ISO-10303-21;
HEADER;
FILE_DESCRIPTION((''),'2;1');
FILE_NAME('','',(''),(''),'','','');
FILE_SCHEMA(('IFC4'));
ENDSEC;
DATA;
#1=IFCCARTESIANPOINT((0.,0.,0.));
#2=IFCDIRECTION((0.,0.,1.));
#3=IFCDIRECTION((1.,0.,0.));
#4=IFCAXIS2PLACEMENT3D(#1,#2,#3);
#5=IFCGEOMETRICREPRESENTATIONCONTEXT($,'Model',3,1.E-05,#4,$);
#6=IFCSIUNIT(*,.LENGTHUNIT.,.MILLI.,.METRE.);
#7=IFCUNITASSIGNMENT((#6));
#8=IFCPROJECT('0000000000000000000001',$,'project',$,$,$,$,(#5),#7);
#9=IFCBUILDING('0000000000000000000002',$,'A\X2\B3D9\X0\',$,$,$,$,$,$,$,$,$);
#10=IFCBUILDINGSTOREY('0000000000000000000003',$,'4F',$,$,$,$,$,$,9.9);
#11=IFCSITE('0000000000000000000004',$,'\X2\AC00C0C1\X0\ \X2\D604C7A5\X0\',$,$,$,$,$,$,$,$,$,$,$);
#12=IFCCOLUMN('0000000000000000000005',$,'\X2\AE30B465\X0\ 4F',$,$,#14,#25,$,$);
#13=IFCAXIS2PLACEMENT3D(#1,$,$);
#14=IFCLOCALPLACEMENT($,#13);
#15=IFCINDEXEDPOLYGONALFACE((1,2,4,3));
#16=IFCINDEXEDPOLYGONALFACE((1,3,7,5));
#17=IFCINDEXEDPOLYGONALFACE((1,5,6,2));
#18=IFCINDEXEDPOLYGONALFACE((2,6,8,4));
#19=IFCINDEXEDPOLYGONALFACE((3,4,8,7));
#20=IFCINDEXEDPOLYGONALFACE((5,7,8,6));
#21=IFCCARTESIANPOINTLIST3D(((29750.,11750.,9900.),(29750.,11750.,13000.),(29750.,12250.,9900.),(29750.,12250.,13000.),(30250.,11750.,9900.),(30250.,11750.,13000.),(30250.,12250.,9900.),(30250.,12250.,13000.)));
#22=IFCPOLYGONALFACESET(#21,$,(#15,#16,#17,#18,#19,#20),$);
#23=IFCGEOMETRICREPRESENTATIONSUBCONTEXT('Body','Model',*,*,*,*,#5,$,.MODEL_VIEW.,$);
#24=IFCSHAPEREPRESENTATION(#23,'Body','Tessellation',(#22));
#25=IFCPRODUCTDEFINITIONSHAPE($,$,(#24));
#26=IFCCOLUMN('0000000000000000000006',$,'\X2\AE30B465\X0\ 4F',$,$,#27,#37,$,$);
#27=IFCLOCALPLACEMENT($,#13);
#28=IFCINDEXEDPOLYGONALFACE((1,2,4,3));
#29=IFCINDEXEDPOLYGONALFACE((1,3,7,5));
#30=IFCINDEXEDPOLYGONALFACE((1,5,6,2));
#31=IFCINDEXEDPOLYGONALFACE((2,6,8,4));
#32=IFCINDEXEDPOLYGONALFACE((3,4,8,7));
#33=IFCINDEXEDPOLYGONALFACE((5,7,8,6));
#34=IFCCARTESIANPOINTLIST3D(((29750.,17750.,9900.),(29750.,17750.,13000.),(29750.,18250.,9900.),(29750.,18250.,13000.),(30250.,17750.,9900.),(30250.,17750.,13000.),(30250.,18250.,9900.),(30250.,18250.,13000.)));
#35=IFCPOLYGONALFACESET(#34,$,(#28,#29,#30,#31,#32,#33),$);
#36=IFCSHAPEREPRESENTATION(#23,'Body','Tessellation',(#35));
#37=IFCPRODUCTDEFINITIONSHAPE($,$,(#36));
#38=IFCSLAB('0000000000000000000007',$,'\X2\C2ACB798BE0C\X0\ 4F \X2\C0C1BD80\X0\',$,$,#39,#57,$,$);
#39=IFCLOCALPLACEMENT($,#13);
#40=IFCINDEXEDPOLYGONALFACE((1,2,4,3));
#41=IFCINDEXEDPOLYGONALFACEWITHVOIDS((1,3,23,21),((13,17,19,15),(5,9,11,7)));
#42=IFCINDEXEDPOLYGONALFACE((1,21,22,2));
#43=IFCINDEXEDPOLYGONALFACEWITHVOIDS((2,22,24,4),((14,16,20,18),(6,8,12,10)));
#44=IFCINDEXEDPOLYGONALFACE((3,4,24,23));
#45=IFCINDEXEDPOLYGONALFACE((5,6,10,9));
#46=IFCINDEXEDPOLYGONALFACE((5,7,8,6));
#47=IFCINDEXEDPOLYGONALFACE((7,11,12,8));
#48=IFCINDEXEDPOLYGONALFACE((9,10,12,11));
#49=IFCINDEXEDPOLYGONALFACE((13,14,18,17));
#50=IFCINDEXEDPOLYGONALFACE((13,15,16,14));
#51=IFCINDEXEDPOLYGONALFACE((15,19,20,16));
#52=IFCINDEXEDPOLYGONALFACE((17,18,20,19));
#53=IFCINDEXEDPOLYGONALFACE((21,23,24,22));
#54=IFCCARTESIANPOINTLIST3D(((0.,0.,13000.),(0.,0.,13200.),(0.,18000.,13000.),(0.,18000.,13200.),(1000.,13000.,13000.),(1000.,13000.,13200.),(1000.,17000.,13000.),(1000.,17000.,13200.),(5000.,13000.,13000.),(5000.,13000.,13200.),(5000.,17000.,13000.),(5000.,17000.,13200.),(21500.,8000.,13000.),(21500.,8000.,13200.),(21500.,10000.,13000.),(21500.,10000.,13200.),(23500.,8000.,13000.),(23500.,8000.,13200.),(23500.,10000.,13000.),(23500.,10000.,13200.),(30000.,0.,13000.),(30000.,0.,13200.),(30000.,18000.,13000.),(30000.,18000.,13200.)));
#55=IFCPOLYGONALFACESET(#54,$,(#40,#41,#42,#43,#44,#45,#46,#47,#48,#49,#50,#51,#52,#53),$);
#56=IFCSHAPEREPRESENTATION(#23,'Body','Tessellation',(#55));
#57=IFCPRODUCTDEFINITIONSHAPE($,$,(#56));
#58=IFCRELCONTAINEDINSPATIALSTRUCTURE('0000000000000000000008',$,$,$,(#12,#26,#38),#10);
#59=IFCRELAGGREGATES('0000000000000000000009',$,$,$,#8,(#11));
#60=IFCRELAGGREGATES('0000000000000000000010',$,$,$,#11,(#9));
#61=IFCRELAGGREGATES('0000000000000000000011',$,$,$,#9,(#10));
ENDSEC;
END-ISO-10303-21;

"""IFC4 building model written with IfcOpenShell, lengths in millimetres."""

from ifc_helpers import new_model, si_unit, frame, origin_with_axes, place, context, subcontext, project, spatial, indexed_curve, outline, extrude, element, save


model = new_model("IFC4")

# Units and contexts
model_context = context("Model", 3, precision=1e-05, world=origin_with_axes())
body_context = subcontext(model_context, "Body", "Model", "MODEL_VIEW")
ifc_project = project(units=[si_unit("LENGTHUNIT", "METRE", prefix="MILLI")], contexts=[model_context])

# Site, building, storey
site = spatial("IfcSite", under=ifc_project, Name="가상 현장")
building = spatial("IfcBuilding", under=site, Name="A동")
storey = spatial("IfcBuildingStorey", under=building, Name="4F", Elevation=9.9)

# Columns
for number, where, z_axis, x_axis, name in (
    (1, (29750.0, 11750.0, 9900.0), (0.0, 0.0, 1.0), (1.0, 0.0, 0.0), "기둥 4F"),
    (2, (29750.0, 17750.0, 9900.0), (0.0, 0.0, 1.0), (1.0, 0.0, 0.0), "기둥 4F"),
):
    element("IfcColumn", number, at=place(None, frame(where, z_axis=z_axis, x_axis=x_axis)), inside=storey, Name=name, context=body_context, shape_type="SweptSolid", body=[
        extrude(outline(indexed_curve([(0.0, 0.0), (0.0, 500.0), (500.0, 500.0), (500.0, 0.0), (0.0, 0.0)], self_intersect=False)), origin_with_axes(), (0.0, 0.0, 1.0), 3100.0),
    ])

# Slab, openings
slab_placement = place(None, frame((0.0, 0.0, 13000.0), z_axis=(0.0, 0.0, 1.0), x_axis=(1.0, 0.0, 0.0)))
slab = element("IfcSlab", 3, at=slab_placement, inside=storey, Name="슬래브 4F 상부", context=body_context, shape_type="SweptSolid", body=[
    extrude(outline(indexed_curve([(0.0, 0.0), (30000.0, 0.0), (30000.0, 18000.0), (0.0, 18000.0)])), None, (0.0, 0.0, 1.0), 200.0),
])
opening_1_placement = place(slab_placement, frame((1000.0, 13000.0, -10.0), z_axis=(0.0, 0.0, 1.0), x_axis=(1.0, 0.0, 0.0)))
element("IfcOpeningElement", 4, at=opening_1_placement, cuts=slab, context=body_context, shape_type="SweptSolid", body=[
    extrude(outline(indexed_curve([(0.0, 0.0), (4000.0, 0.0), (4000.0, 4000.0), (0.0, 4000.0)])), None, (0.0, 0.0, 1.0), 220.0),
])
opening_2_placement = place(slab_placement, frame((21500.0, 8000.0, -10.0), z_axis=(0.0, 0.0, 1.0), x_axis=(1.0, 0.0, 0.0)))
element("IfcOpeningElement", 5, at=opening_2_placement, cuts=slab, context=body_context, shape_type="SweptSolid", body=[
    extrude(outline(indexed_curve([(0.0, 0.0), (2000.0, 0.0), (2000.0, 2000.0), (0.0, 2000.0)])), None, (0.0, 0.0, 1.0), 220.0),
])

save(model, "model.ifc")
